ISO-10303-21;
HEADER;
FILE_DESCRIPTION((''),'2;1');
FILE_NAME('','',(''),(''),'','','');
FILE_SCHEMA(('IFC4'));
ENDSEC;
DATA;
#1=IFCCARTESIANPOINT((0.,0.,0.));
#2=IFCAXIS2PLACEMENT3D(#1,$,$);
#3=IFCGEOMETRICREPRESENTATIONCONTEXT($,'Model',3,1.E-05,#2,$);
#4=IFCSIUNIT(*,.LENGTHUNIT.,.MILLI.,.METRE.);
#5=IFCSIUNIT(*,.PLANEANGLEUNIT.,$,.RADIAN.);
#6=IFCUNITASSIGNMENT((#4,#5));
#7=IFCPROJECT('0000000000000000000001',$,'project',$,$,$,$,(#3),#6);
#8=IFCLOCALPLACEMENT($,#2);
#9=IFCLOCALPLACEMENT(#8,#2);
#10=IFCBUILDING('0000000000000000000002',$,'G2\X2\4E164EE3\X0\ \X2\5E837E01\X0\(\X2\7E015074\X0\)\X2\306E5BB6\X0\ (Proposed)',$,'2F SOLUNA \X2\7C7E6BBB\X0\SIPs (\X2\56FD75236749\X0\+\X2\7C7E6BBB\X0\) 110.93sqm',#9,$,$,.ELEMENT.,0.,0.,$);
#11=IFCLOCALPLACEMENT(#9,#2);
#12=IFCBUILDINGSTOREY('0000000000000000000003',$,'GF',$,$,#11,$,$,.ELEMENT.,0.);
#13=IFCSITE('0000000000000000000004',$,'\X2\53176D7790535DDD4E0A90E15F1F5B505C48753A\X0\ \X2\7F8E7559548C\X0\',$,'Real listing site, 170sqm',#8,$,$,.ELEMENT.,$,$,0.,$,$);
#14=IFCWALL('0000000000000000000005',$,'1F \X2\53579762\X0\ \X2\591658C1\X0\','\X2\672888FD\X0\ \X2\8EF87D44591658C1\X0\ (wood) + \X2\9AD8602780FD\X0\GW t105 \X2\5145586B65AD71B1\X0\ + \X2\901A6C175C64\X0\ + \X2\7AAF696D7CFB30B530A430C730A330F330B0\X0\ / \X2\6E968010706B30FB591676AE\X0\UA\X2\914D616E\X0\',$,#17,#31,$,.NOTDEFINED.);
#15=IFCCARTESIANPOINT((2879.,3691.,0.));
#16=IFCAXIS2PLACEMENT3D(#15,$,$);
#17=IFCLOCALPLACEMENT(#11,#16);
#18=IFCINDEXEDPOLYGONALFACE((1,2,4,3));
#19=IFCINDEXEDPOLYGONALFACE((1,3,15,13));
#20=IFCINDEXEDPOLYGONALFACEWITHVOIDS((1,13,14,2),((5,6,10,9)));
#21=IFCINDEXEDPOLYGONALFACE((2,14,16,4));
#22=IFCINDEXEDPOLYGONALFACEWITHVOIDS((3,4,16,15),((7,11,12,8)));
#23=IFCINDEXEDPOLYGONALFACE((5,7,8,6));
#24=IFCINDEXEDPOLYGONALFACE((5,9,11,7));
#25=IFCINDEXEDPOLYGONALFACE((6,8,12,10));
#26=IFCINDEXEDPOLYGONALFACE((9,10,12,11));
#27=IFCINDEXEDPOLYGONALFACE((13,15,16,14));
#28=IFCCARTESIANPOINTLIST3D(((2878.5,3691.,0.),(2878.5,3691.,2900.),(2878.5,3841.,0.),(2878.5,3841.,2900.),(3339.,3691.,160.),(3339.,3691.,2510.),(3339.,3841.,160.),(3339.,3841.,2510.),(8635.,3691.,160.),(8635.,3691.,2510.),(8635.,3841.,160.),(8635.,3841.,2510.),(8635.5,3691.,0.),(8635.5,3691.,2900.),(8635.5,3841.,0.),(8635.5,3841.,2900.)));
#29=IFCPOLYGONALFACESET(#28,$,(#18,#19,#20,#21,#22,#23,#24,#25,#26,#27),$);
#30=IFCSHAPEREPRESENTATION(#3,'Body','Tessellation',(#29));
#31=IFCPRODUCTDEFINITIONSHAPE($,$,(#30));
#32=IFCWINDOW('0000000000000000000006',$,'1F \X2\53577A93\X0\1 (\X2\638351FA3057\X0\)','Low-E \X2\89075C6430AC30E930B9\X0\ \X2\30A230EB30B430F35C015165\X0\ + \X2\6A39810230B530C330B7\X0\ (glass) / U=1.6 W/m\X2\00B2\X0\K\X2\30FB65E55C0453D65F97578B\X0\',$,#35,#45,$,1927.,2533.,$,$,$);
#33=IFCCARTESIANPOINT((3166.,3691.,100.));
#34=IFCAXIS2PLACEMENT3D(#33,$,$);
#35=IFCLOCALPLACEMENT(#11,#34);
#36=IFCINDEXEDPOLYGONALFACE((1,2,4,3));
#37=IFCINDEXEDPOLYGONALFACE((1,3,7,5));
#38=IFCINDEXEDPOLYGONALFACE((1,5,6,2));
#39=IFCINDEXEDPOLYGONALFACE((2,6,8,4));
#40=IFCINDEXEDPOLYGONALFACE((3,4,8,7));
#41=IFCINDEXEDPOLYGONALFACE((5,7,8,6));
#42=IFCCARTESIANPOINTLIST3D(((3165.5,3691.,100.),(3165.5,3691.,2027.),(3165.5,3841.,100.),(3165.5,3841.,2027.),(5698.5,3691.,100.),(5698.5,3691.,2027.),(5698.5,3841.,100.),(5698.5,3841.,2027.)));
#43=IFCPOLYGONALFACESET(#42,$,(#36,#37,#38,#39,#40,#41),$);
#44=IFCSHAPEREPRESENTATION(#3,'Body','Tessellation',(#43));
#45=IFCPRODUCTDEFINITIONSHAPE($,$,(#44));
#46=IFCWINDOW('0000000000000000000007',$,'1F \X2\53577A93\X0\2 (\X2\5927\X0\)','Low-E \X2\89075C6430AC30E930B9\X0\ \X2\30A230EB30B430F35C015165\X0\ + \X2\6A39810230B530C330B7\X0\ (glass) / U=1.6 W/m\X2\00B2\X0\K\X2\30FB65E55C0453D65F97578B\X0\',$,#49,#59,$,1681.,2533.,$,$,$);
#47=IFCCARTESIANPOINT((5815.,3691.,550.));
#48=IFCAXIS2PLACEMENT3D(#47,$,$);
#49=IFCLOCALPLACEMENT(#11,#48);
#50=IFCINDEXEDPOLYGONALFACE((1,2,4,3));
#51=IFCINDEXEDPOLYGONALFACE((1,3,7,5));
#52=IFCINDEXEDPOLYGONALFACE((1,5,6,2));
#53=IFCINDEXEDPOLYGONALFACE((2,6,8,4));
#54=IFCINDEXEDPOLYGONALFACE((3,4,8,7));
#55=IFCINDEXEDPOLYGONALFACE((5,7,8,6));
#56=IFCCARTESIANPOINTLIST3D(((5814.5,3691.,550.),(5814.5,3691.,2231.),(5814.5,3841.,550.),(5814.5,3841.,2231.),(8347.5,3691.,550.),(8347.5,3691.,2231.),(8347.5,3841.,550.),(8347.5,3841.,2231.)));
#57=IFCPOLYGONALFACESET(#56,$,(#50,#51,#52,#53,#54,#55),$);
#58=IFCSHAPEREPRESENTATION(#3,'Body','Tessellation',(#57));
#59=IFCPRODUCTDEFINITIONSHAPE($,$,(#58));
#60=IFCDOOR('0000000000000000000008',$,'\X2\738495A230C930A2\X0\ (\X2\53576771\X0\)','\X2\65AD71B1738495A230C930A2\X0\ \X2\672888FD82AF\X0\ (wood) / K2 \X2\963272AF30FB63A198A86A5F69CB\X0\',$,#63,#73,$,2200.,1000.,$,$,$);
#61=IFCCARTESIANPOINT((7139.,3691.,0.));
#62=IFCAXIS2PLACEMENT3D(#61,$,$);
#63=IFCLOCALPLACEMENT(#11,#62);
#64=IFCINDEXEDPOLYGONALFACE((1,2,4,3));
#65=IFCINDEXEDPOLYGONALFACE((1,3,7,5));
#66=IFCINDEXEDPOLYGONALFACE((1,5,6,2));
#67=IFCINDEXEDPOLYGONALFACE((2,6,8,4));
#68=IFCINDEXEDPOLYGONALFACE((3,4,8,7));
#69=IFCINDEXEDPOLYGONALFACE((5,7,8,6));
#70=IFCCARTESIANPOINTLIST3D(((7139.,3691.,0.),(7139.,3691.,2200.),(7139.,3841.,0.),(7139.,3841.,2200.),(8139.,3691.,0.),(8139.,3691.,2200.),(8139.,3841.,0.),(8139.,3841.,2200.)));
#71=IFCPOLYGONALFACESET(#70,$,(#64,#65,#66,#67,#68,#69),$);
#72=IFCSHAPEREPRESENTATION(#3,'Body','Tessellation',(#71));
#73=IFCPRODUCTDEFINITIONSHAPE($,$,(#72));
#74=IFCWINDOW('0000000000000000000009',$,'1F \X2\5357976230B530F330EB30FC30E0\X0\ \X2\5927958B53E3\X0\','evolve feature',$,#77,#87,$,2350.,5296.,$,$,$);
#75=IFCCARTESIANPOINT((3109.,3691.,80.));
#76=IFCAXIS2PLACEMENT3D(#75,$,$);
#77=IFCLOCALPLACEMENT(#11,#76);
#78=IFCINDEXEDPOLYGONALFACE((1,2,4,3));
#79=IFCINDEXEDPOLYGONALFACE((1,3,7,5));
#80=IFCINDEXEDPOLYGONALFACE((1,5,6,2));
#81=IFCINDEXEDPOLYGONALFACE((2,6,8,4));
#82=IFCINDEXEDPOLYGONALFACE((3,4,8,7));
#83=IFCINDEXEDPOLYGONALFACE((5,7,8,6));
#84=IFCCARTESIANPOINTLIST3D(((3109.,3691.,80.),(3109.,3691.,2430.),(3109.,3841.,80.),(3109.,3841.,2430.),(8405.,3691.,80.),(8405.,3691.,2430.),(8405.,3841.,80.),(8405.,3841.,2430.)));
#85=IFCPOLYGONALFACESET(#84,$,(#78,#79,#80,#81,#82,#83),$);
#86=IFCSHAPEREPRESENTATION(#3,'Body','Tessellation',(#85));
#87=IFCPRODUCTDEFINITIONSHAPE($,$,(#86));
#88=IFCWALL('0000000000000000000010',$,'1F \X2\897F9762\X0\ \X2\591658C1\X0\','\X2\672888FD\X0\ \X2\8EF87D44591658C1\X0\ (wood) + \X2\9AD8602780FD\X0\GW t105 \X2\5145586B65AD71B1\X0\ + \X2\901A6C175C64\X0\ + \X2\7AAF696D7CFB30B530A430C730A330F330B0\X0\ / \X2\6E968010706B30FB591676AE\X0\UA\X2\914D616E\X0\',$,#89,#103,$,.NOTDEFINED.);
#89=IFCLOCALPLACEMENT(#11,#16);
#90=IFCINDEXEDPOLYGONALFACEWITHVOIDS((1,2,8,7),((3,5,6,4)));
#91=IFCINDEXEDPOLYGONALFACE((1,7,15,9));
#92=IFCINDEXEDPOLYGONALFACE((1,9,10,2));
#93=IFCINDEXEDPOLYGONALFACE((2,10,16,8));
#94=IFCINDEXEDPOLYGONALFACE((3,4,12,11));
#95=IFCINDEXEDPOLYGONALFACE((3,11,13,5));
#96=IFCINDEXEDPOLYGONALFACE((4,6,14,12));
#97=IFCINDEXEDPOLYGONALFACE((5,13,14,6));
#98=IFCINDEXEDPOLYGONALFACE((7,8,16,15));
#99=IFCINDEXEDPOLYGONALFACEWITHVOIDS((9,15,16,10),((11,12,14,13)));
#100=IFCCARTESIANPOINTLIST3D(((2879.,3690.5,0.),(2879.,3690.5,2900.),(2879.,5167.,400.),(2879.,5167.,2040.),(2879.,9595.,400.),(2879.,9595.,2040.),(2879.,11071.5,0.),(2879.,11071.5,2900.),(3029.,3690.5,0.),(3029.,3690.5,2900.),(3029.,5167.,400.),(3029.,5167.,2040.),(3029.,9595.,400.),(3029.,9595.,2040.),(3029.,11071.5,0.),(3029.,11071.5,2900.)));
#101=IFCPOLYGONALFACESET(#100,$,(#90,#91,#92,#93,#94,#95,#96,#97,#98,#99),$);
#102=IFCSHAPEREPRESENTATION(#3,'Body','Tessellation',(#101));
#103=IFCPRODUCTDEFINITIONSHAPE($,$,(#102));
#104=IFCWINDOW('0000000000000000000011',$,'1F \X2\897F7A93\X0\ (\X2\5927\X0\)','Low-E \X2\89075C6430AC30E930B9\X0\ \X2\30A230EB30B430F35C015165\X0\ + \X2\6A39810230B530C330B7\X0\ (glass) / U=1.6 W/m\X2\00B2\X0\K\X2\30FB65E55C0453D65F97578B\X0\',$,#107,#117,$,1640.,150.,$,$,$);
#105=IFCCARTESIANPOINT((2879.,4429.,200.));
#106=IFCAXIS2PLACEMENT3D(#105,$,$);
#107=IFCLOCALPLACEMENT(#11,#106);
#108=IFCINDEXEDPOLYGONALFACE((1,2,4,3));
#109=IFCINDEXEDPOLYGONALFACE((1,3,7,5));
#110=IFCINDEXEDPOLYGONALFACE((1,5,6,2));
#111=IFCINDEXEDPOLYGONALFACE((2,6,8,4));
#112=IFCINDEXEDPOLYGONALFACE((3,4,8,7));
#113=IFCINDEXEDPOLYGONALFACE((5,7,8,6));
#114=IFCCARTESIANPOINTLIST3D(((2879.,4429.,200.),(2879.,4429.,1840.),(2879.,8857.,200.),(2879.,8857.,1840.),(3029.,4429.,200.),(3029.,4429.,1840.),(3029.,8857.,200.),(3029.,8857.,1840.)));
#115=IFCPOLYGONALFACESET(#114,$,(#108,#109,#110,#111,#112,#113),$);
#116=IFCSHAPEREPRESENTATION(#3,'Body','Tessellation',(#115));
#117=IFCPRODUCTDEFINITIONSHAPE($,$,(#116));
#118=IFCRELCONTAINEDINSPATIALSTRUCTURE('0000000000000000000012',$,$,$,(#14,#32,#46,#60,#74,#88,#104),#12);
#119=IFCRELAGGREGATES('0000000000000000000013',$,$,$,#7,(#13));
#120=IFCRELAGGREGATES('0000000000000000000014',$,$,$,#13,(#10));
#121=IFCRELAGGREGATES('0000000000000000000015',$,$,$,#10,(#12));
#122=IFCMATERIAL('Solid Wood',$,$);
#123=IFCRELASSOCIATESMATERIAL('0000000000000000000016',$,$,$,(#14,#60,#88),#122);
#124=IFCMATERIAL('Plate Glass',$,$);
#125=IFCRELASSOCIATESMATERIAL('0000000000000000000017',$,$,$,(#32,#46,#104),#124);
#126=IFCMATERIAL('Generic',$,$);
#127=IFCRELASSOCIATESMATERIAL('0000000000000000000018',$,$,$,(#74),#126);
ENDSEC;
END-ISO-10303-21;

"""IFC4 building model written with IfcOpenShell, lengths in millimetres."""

from ifc_helpers import new_model, si_unit, frame, frame_2d, origin, place, context, project, spatial, rectangle, extrude, material, element, fill, save


model = new_model("IFC4")

# Units and contexts
model_context = context("Model", 3, precision=1e-05, world=origin())
ifc_project = project(units=[si_unit("LENGTHUNIT", "METRE", prefix="MILLI"), si_unit("PLANEANGLEUNIT", "RADIAN")], contexts=[model_context])

# Site, building, storey
site_placement = place(None, origin())
site = spatial("IfcSite", under=ifc_project, at=site_placement, Name="北海道川上郡弟子屈町 美留和", ObjectType="Real listing site, 170sqm", CompositionType="ELEMENT", RefElevation=0.0)
building_placement = place(site_placement, origin())
building = spatial("IfcBuilding", under=site, at=building_placement, Name="G2世代 広縁(縁側)の家 (Proposed)", ObjectType="2F SOLUNA 籾殻SIPs (国産杉+籾殻) 110.93sqm", CompositionType="ELEMENT", ElevationOfRefHeight=0.0, ElevationOfTerrain=0.0)
storey_placement = place(building_placement, origin())
storey = spatial("IfcBuildingStorey", under=building, at=storey_placement, Name="GF", CompositionType="ELEMENT", Elevation=0.0)

# Shared definitions
ifc_material_1 = material(Name="Solid Wood")
ifc_material_2 = material(Name="Generic")

# Wall, openings, windows, door
wall_1_placement = place(storey_placement, frame((2879.0, 3691.0, 0.0)))
wall_1 = element("IfcWall", 1, at=wall_1_placement, inside=storey, material=ifc_material_1, Name="1F 南面 外壁", Description="木製 軸組外壁 (wood) + 高性能GW t105 充填断熱 + 通気層 + 窯業系サイディング / 準耐火・外皮UA配慮", PredefinedType="NOTDEFINED", context=model_context, shape_type="SweptSolid", body=[
    extrude(rectangle(XDim=5757.0, YDim=150.0, at=frame_2d((2878.0, 75.0))), frame((2879.0, 3691.0, 0.0)), (0.0, 0.0, 1.0), 2900.0),
])
opening_1_placement = place(storey_placement, frame((3166.0, 3691.0, 100.0)))
opening_1 = element("IfcOpeningElement", 2, at=opening_1_placement, cuts=wall_1, PredefinedType="NOTDEFINED", context=model_context, shape_type="SweptSolid", body=[
    extrude(rectangle(XDim=2533.0, YDim=150.0, at=frame_2d((1266.0, 75.0))), frame((3166.0, 3691.0, 100.0)), (0.0, 0.0, 1.0), 1927.0),
])
opening_2_placement = place(storey_placement, frame((5815.0, 3691.0, 550.0)))
opening_2 = element("IfcOpeningElement", 3, at=opening_2_placement, cuts=wall_1, PredefinedType="NOTDEFINED", context=model_context, shape_type="SweptSolid", body=[
    extrude(rectangle(XDim=2533.0, YDim=150.0, at=frame_2d((1266.0, 75.0))), frame((5815.0, 3691.0, 550.0)), (0.0, 0.0, 1.0), 1681.0),
])
opening_3_placement = place(storey_placement, frame((7139.0, 3691.0, 0.0)))
opening_3 = element("IfcOpeningElement", 4, at=opening_3_placement, cuts=wall_1, PredefinedType="NOTDEFINED", context=model_context, shape_type="SweptSolid", body=[
    extrude(rectangle(XDim=1000.0, YDim=150.0, at=frame_2d((500.0, 75.0))), frame((7139.0, 3691.0, 0.0)), (0.0, 0.0, 1.0), 2200.0),
])
opening_4_placement = place(storey_placement, frame((3109.0, 3691.0, 80.0)))
opening_4 = element("IfcOpeningElement", 5, at=opening_4_placement, cuts=wall_1, PredefinedType="NOTDEFINED", context=model_context, shape_type="SweptSolid", body=[
    extrude(rectangle(XDim=5296.0, YDim=150.0, at=frame_2d((2648.0, 75.0))), frame((3109.0, 3691.0, 80.0)), (0.0, 0.0, 1.0), 2350.0),
])
ifc_material_3 = material(Name="Plate Glass")
window_1_placement = place(storey_placement, frame((3166.0, 3691.0, 100.0)))
window_1 = element("IfcWindow", 6, at=window_1_placement, inside=storey, material=ifc_material_3, Name="1F 南窓1 (掃出し)", Description="Low-E 複層ガラス アルゴン封入 + 樹脂サッシ (glass) / U=1.6 W/m²K・日射取得型", OverallHeight=1927.0, OverallWidth=2533.0, context=model_context, shape_type="SweptSolid", body=[
    extrude(rectangle(XDim=2533.0, YDim=150.0, at=frame_2d((1266.0, 75.0))), frame((3166.0, 3691.0, 100.0)), (0.0, 0.0, 1.0), 1927.0),
])
fill(opening_1, window_1)
window_2_placement = place(storey_placement, frame((5815.0, 3691.0, 550.0)))
window_2 = element("IfcWindow", 7, at=window_2_placement, inside=storey, material=ifc_material_3, Name="1F 南窓2 (大)", Description="Low-E 複層ガラス アルゴン封入 + 樹脂サッシ (glass) / U=1.6 W/m²K・日射取得型", OverallHeight=1681.0, OverallWidth=2533.0, context=model_context, shape_type="SweptSolid", body=[
    extrude(rectangle(XDim=2533.0, YDim=150.0, at=frame_2d((1266.0, 75.0))), frame((5815.0, 3691.0, 550.0)), (0.0, 0.0, 1.0), 1681.0),
])
fill(opening_2, window_2)
door_placement = place(storey_placement, frame((7139.0, 3691.0, 0.0)))
door = element("IfcDoor", 8, at=door_placement, inside=storey, material=ifc_material_1, Name="玄関ドア (南東)", Description="断熱玄関ドア 木製芯 (wood) / K2 防犯・採風機構", OverallHeight=2200.0, OverallWidth=1000.0, context=model_context, shape_type="SweptSolid", body=[
    extrude(rectangle(XDim=1000.0, YDim=150.0, at=frame_2d((500.0, 75.0))), frame((7139.0, 3691.0, 0.0)), (0.0, 0.0, 1.0), 2200.0),
])
fill(opening_3, door)
window_3_placement = place(storey_placement, frame((3109.0, 3691.0, 80.0)))
window_3 = element("IfcWindow", 9, at=window_3_placement, inside=storey, material=ifc_material_2, Name="1F 南面サンルーム 大開口", Description="evolve feature", OverallHeight=2350.0, OverallWidth=5296.0, context=model_context, shape_type="SweptSolid", body=[
    extrude(rectangle(XDim=5296.0, YDim=150.0, at=frame_2d((2648.0, 75.0))), frame((3109.0, 3691.0, 80.0)), (0.0, 0.0, 1.0), 2350.0),
])
fill(opening_4, window_3)

# Wall, opening, window
wall_2_placement = place(storey_placement, frame((2879.0, 3691.0, 0.0)))
wall_2 = element("IfcWall", 10, at=wall_2_placement, inside=storey, material=ifc_material_1, Name="1F 西面 外壁", Description="木製 軸組外壁 (wood) + 高性能GW t105 充填断熱 + 通気層 + 窯業系サイディング / 準耐火・外皮UA配慮", PredefinedType="NOTDEFINED", context=model_context, shape_type="SweptSolid", body=[
    extrude(rectangle(XDim=150.0, YDim=7381.0, at=frame_2d((75.0, 3690.0))), frame((2879.0, 3691.0, 0.0)), (0.0, 0.0, 1.0), 2900.0),
])
opening_5_placement = place(storey_placement, frame((2879.0, 4429.0, 200.0)))
opening_5 = element("IfcOpeningElement", 11, at=opening_5_placement, cuts=wall_2, PredefinedType="NOTDEFINED", context=model_context, shape_type="SweptSolid", body=[
    extrude(rectangle(XDim=150.0, YDim=4428.0, at=frame_2d((75.0, 2214.0))), frame((2879.0, 4429.0, 200.0)), (0.0, 0.0, 1.0), 1640.0),
])
window_4_placement = place(storey_placement, frame((2879.0, 4429.0, 200.0)))
window_4 = element("IfcWindow", 12, at=window_4_placement, inside=storey, material=ifc_material_3, Name="1F 西窓 (大)", Description="Low-E 複層ガラス アルゴン封入 + 樹脂サッシ (glass) / U=1.6 W/m²K・日射取得型", OverallHeight=1640.0, OverallWidth=150.0, context=model_context, shape_type="SweptSolid", body=[
    extrude(rectangle(XDim=150.0, YDim=4428.0, at=frame_2d((75.0, 2214.0))), frame((2879.0, 4429.0, 200.0)), (0.0, 0.0, 1.0), 1640.0),
])
fill(opening_5, window_4)

save(model, "model.ifc")
